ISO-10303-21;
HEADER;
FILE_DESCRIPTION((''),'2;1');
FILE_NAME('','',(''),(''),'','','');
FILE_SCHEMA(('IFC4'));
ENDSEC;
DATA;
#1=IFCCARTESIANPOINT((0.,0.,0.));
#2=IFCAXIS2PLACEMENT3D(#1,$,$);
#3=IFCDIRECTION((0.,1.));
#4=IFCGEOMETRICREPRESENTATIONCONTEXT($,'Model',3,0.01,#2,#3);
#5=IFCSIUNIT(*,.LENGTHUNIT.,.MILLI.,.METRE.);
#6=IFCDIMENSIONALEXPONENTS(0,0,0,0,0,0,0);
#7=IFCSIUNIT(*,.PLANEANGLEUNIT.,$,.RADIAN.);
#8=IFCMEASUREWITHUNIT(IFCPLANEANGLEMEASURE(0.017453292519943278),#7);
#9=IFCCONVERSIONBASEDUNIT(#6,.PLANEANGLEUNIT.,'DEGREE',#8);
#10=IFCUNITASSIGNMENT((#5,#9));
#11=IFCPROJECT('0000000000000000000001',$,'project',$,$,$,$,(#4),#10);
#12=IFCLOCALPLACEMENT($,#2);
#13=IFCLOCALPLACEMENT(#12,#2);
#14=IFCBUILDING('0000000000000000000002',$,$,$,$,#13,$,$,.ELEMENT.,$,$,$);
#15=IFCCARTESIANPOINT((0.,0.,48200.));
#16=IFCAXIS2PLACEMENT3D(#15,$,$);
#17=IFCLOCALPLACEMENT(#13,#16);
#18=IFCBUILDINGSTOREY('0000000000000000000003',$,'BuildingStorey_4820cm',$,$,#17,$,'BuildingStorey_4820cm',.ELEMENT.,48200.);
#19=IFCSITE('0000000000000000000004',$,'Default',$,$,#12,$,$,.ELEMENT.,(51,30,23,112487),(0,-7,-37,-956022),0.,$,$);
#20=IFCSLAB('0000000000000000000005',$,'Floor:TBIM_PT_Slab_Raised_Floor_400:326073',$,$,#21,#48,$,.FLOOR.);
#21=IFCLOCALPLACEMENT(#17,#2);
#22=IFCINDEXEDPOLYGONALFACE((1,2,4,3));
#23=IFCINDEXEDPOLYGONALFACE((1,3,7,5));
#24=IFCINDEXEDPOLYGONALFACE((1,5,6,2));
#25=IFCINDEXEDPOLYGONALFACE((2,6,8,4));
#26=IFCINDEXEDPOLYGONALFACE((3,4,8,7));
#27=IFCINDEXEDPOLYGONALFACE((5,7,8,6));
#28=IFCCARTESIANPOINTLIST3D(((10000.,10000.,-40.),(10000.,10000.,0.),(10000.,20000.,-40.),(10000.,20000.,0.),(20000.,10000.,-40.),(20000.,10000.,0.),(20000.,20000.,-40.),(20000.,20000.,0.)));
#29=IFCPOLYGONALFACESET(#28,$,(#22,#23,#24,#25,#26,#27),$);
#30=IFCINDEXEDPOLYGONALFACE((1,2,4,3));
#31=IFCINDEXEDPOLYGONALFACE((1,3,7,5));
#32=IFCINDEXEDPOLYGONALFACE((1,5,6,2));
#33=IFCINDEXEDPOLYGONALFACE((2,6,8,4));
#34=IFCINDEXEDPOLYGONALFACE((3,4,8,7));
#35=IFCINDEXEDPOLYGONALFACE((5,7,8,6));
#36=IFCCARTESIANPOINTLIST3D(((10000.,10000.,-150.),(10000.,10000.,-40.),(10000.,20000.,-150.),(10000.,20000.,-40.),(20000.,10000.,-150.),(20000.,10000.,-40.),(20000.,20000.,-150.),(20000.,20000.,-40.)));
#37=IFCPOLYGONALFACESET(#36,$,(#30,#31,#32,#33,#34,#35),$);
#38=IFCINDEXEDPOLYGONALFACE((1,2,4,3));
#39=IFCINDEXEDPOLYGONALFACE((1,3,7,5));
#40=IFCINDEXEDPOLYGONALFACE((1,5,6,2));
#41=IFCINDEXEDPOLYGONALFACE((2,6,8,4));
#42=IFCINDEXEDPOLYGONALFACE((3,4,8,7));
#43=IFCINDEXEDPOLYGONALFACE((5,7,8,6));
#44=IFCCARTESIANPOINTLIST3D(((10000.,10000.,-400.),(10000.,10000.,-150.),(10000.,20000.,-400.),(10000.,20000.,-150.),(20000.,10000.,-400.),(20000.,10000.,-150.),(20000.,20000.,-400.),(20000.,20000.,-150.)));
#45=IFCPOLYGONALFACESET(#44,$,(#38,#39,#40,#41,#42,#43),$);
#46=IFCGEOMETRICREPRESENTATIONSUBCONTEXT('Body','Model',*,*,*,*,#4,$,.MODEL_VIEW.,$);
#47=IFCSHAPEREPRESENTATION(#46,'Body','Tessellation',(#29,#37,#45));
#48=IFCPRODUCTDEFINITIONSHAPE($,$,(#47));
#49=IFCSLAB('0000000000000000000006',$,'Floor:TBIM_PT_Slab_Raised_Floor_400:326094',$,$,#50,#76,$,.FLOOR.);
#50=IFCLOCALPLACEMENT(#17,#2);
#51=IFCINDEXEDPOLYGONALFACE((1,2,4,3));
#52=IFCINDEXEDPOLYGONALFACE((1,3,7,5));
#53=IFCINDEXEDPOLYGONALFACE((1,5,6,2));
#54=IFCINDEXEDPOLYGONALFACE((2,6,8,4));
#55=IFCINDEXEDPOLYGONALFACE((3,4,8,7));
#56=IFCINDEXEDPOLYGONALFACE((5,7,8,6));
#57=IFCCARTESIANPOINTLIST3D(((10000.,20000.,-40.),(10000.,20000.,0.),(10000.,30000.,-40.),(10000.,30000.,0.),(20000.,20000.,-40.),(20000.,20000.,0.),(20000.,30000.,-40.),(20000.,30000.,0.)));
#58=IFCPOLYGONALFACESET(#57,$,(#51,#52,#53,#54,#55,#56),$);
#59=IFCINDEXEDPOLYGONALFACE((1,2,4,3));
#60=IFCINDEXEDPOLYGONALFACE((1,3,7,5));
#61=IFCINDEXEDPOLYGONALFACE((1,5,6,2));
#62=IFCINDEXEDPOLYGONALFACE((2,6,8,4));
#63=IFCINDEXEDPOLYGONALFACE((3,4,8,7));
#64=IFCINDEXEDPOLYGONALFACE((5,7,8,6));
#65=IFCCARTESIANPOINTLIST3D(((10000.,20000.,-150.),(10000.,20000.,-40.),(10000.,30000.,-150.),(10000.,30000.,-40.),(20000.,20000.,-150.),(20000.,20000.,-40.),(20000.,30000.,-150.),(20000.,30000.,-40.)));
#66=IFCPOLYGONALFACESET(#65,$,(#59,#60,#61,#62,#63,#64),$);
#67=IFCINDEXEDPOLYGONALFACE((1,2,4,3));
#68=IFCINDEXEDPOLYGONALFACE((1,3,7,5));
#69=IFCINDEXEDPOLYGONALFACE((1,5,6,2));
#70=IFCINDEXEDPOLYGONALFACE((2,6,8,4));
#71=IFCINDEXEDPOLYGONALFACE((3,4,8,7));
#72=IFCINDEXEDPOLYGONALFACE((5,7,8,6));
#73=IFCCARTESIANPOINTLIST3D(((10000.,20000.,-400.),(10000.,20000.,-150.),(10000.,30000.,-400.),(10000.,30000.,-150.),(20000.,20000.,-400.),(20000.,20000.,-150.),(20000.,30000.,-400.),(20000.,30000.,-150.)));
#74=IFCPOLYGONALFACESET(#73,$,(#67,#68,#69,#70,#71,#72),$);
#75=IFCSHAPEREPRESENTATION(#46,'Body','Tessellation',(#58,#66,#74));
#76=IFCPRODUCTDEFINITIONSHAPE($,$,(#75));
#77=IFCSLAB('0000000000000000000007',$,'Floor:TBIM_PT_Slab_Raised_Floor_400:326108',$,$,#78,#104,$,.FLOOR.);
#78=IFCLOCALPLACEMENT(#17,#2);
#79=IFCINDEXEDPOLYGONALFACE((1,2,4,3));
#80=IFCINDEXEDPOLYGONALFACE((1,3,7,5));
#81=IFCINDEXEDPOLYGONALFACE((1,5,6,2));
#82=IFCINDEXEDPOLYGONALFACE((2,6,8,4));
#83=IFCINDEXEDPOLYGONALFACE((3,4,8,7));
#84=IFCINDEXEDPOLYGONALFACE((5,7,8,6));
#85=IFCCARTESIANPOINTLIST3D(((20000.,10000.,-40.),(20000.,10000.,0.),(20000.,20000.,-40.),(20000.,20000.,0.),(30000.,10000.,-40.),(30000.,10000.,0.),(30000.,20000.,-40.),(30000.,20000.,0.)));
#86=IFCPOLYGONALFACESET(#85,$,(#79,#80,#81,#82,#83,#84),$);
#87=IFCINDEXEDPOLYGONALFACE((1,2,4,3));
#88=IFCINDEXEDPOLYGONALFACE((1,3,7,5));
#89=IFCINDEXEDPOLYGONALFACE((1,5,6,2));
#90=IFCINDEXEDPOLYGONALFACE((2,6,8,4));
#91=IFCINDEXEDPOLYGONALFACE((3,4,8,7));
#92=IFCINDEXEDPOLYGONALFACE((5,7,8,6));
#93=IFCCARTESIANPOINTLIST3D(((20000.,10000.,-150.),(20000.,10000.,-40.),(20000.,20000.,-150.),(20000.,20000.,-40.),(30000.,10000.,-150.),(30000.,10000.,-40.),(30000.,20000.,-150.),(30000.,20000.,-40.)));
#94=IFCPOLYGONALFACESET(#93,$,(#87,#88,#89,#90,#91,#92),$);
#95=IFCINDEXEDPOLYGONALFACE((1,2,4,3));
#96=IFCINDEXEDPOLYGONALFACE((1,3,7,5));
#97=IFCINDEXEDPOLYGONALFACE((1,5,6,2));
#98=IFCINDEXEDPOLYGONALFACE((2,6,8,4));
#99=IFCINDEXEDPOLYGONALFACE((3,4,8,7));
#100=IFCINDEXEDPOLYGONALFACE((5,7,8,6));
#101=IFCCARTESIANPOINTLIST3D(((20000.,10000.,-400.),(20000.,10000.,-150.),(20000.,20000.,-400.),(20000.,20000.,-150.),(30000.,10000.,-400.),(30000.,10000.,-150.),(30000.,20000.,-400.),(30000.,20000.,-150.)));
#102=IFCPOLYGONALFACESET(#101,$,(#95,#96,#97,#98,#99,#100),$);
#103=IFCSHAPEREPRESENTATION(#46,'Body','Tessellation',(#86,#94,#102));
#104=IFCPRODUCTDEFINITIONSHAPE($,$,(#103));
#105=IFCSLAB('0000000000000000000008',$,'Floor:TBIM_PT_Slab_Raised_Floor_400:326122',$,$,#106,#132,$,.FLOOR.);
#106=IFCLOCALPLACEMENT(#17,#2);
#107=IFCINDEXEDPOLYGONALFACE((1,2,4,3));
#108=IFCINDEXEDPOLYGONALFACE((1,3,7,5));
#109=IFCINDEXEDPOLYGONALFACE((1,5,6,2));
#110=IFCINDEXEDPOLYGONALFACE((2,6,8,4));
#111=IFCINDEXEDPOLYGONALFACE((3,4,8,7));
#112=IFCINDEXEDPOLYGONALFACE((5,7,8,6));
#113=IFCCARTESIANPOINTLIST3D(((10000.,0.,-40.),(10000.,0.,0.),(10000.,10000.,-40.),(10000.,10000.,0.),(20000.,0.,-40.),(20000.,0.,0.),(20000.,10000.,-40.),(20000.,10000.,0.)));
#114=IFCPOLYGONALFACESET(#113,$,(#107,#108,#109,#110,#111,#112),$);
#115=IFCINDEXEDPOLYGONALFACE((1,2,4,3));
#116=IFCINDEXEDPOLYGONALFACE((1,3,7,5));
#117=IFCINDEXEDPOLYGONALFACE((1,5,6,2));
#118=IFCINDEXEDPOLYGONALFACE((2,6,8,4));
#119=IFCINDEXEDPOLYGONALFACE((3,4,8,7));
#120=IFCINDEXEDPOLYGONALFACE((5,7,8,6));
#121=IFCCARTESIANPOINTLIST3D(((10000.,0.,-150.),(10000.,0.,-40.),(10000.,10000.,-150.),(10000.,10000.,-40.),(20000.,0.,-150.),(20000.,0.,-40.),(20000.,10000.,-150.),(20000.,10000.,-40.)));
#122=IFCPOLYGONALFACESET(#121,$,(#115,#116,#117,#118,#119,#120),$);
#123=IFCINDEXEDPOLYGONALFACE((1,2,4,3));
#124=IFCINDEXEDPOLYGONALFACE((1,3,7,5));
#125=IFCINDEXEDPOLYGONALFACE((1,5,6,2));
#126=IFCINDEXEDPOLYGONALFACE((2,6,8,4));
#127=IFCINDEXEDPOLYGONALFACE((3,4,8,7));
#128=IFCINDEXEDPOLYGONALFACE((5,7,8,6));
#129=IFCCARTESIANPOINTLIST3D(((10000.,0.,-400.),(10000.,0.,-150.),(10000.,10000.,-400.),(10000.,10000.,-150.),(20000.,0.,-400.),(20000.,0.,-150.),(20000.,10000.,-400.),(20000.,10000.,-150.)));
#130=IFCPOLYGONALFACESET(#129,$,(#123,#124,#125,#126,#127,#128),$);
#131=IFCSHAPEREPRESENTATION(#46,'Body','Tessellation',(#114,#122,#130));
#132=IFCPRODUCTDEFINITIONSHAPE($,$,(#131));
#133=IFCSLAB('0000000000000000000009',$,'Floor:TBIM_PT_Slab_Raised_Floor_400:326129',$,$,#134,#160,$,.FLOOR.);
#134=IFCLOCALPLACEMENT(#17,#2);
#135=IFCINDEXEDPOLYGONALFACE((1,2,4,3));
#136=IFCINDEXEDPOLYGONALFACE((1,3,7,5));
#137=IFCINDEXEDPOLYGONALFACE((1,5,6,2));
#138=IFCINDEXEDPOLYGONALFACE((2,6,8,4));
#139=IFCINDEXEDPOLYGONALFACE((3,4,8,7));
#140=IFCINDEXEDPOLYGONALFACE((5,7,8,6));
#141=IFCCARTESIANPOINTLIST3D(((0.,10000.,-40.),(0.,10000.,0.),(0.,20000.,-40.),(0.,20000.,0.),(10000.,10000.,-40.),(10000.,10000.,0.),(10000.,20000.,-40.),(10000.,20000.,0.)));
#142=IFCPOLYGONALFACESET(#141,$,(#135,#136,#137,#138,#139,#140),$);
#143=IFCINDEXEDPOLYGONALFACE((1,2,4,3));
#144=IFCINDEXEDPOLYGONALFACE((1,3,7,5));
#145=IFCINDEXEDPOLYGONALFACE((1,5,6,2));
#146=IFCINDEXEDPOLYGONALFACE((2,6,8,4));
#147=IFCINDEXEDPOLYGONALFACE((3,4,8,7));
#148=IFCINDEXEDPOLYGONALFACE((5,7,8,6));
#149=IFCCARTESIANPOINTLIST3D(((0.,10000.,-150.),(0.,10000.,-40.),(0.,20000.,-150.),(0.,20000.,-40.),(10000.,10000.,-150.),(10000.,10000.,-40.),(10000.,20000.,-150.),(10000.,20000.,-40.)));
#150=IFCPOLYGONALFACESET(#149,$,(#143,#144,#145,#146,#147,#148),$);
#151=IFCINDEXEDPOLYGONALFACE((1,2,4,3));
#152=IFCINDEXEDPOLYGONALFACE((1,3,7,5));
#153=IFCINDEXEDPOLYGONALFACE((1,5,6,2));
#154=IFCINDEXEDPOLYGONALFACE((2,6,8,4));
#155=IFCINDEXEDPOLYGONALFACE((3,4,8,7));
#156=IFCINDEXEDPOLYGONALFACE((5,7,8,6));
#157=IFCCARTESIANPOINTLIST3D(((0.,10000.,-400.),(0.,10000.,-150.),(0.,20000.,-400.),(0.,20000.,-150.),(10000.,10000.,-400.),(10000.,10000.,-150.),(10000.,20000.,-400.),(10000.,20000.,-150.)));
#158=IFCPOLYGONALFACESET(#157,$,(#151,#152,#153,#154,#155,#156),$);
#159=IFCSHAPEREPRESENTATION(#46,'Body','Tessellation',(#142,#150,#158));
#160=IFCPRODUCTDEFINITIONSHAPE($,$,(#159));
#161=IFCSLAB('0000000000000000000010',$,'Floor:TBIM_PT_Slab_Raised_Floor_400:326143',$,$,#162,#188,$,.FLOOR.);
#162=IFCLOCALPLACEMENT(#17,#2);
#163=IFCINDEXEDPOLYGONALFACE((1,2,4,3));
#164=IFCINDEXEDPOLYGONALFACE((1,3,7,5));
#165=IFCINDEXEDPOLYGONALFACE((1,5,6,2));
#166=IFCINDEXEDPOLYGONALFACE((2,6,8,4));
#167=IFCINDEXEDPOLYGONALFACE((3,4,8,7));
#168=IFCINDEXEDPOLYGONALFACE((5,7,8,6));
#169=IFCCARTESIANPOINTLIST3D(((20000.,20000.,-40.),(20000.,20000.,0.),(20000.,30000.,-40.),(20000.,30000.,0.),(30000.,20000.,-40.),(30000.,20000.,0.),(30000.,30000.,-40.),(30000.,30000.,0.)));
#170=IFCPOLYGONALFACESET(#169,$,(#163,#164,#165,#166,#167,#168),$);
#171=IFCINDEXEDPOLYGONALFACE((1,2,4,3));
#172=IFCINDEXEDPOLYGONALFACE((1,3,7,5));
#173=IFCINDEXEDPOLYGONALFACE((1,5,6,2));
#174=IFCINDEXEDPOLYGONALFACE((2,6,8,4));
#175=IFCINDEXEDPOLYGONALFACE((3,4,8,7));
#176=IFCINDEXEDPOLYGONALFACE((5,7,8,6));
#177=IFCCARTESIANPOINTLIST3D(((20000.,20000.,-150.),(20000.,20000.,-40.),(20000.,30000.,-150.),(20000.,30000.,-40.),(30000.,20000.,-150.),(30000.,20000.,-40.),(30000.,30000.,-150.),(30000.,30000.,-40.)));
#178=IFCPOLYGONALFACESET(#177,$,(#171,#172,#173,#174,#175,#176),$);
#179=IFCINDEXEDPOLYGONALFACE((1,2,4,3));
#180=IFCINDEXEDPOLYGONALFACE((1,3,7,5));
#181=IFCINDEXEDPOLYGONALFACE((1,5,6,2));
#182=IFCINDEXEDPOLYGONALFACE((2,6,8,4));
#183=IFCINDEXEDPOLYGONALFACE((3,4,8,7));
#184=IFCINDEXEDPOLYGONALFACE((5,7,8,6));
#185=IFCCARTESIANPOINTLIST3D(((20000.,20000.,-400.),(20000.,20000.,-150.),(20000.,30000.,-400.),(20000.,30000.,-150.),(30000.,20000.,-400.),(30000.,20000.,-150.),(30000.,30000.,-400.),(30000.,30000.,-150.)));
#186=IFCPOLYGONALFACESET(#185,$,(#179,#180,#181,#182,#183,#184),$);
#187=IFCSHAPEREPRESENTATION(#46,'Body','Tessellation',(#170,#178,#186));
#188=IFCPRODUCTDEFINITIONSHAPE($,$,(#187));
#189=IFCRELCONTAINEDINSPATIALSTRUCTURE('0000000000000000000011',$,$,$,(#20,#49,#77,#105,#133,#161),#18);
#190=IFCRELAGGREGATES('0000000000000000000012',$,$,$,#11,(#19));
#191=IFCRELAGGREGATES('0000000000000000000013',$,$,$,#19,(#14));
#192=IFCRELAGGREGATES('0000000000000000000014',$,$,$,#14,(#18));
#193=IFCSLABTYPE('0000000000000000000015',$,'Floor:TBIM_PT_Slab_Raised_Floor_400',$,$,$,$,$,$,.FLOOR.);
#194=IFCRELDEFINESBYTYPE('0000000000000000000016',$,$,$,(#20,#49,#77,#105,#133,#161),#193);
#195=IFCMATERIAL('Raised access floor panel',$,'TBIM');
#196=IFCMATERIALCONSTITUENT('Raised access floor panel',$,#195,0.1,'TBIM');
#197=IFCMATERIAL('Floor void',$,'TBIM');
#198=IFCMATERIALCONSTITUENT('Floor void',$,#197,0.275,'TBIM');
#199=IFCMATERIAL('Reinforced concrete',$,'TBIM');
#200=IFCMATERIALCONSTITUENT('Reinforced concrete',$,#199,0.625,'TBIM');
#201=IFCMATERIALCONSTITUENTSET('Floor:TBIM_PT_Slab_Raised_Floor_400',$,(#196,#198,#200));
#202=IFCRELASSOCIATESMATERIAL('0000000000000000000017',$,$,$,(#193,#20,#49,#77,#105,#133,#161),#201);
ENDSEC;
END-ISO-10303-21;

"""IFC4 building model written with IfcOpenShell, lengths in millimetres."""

from ifc_helpers import new_model, entity, si_unit, converted_unit, direction, frame, origin, place, context, subcontext, project, spatial, indexed_curve, outline, extrude, material, constituent, constituent_set, type_object, element, save


model = new_model("IFC4")

# Units and contexts
model_context = context("Model", 3, precision=0.01, world=origin(), true_north=direction((0.0, 1.0)))
body_context = subcontext(model_context, "Body", "Model", "MODEL_VIEW")
ifc_project = project(units=[si_unit("LENGTHUNIT", "METRE", prefix="MILLI"), converted_unit("PLANEANGLEUNIT", "DEGREE", entity("IfcPlaneAngleMeasure", 0.017453292519943278), si_unit("PLANEANGLEUNIT", "RADIAN"), dimensions=[0, 0, 0, 0, 0, 0, 0])], contexts=[model_context])

# Site, building, storey
site_placement = place(None, origin())
site = spatial("IfcSite", under=ifc_project, at=site_placement, Name="Default", CompositionType="ELEMENT", RefLatitude=(51, 30, 23, 112487), RefLongitude=(0, -7, -37, -956022), RefElevation=0.0)
building_placement = place(site_placement, origin())
building = spatial("IfcBuilding", under=site, at=building_placement, CompositionType="ELEMENT")
storey_placement = place(building_placement, frame((0.0, 0.0, 48200.0)))
storey = spatial("IfcBuildingStorey", under=building, at=storey_placement, Name="BuildingStorey_4820cm", LongName="BuildingStorey_4820cm", CompositionType="ELEMENT", Elevation=48200.0)

# Slabs
ifc_material_1 = material(Name="Raised access floor panel", Category="TBIM")
ifc_constituent_1 = constituent(ifc_material_1, Name="Raised access floor panel", Category="TBIM", fraction=0.1)
ifc_material_2 = material(Name="Floor void", Category="TBIM")
ifc_constituent_2 = constituent(ifc_material_2, Name="Floor void", Category="TBIM", fraction=0.275)
ifc_material_3 = material(Name="Reinforced concrete", Category="TBIM")
ifc_constituent_3 = constituent(ifc_material_3, Name="Reinforced concrete", Category="TBIM", fraction=0.625)
ifc_constituent_set_1 = constituent_set(constituents=[ifc_constituent_1, ifc_constituent_2, ifc_constituent_3], Name="Floor:TBIM_PT_Slab_Raised_Floor_400")
slab_type = type_object("IfcSlabType", Name="Floor:TBIM_PT_Slab_Raised_Floor_400", PredefinedType="FLOOR", material=ifc_constituent_set_1)
slab_1_placement = place(storey_placement, origin())
element("IfcSlab", 1, at=slab_1_placement, inside=storey, type_object=slab_type, material=ifc_constituent_set_1, Name="Floor:TBIM_PT_Slab_Raised_Floor_400:326073", PredefinedType="FLOOR", context=body_context, shape_type="SweptSolid", body=[
    extrude(outline(indexed_curve([(-5000.0, -5000.0), (5000.0, -5000.0), (5000.0, 5000.0), (-5000.0, 5000.0), (-5000.0, -5000.0)], self_intersect=False)), frame((15000.0, 15000.0, -40.0), z_axis=(0.0, 0.0, 1.0), x_axis=(-1.0, 0.0, 0.0)), (0.0, 0.0, 1.0), 40.0),
    extrude(outline(indexed_curve([(-5000.0, -5000.0), (5000.0, -5000.0), (5000.0, 5000.0), (-5000.0, 5000.0), (-5000.0, -5000.0)], self_intersect=False)), frame((15000.0, 15000.0, -150.0), z_axis=(0.0, 0.0, 1.0), x_axis=(-1.0, 0.0, 0.0)), (0.0, 0.0, 1.0), 110.0),
    extrude(outline(indexed_curve([(-5000.0, -5000.0), (5000.0, -5000.0), (5000.0, 5000.0), (-5000.0, 5000.0), (-5000.0, -5000.0)], self_intersect=False)), frame((15000.0, 15000.0, -400.0), z_axis=(0.0, 0.0, 1.0), x_axis=(-1.0, 0.0, 0.0)), (0.0, 0.0, 1.0), 250.0),
])
slab_2_placement = place(storey_placement, origin())
element("IfcSlab", 2, at=slab_2_placement, inside=storey, type_object=slab_type, material=ifc_constituent_set_1, Name="Floor:TBIM_PT_Slab_Raised_Floor_400:326094", PredefinedType="FLOOR", context=body_context, shape_type="SweptSolid", body=[
    extrude(outline(indexed_curve([(-5000.0, -5000.0), (5000.0, -5000.0), (5000.0, 5000.0), (-5000.0, 5000.0), (-5000.0, -5000.0)], self_intersect=False)), frame((15000.0, 25000.0, -40.0), z_axis=(0.0, 0.0, 1.0), x_axis=(-1.0, 0.0, 0.0)), (0.0, 0.0, 1.0), 40.0),
    extrude(outline(indexed_curve([(-5000.0, -5000.0), (5000.0, -5000.0), (5000.0, 5000.0), (-5000.0, 5000.0), (-5000.0, -5000.0)], self_intersect=False)), frame((15000.0, 25000.0, -150.0), z_axis=(0.0, 0.0, 1.0), x_axis=(-1.0, 0.0, 0.0)), (0.0, 0.0, 1.0), 110.0),
    extrude(outline(indexed_curve([(-5000.0, -5000.0), (5000.0, -5000.0), (5000.0, 5000.0), (-5000.0, 5000.0), (-5000.0, -5000.0)], self_intersect=False)), frame((15000.0, 25000.0, -400.0), z_axis=(0.0, 0.0, 1.0), x_axis=(-1.0, 0.0, 0.0)), (0.0, 0.0, 1.0), 250.0),
])
slab_3_placement = place(storey_placement, origin())
element("IfcSlab", 3, at=slab_3_placement, inside=storey, type_object=slab_type, material=ifc_constituent_set_1, Name="Floor:TBIM_PT_Slab_Raised_Floor_400:326108", PredefinedType="FLOOR", context=body_context, shape_type="SweptSolid", body=[
    extrude(outline(indexed_curve([(-5000.0, -5000.0), (5000.0, -5000.0), (5000.0, 5000.0), (-5000.0, 5000.0), (-5000.0, -5000.0)], self_intersect=False)), frame((25000.0, 15000.0, -40.0), z_axis=(0.0, 0.0, 1.0), x_axis=(-1.0, 0.0, 0.0)), (0.0, 0.0, 1.0), 40.0),
    extrude(outline(indexed_curve([(-5000.0, -5000.0), (5000.0, -5000.0), (5000.0, 5000.0), (-5000.0, 5000.0), (-5000.0, -5000.0)], self_intersect=False)), frame((25000.0, 15000.0, -150.0), z_axis=(0.0, 0.0, 1.0), x_axis=(-1.0, 0.0, 0.0)), (0.0, 0.0, 1.0), 110.0),
    extrude(outline(indexed_curve([(-5000.0, -5000.0), (5000.0, -5000.0), (5000.0, 5000.0), (-5000.0, 5000.0), (-5000.0, -5000.0)], self_intersect=False)), frame((25000.0, 15000.0, -400.0), z_axis=(0.0, 0.0, 1.0), x_axis=(-1.0, 0.0, 0.0)), (0.0, 0.0, 1.0), 250.0),
])
slab_4_placement = place(storey_placement, origin())
element("IfcSlab", 4, at=slab_4_placement, inside=storey, type_object=slab_type, material=ifc_constituent_set_1, Name="Floor:TBIM_PT_Slab_Raised_Floor_400:326122", PredefinedType="FLOOR", context=body_context, shape_type="SweptSolid", body=[
    extrude(outline(indexed_curve([(-5000.0, -5000.0), (5000.0, -5000.0), (5000.0, 5000.0), (-5000.0, 5000.0), (-5000.0, -5000.0)], self_intersect=False)), frame((15000.0, 5000.0, -40.0), z_axis=(0.0, 0.0, 1.0), x_axis=(0.0, 1.0, 0.0)), (0.0, 0.0, 1.0), 40.0),
    extrude(outline(indexed_curve([(-5000.0, -5000.0), (5000.0, -5000.0), (5000.0, 5000.0), (-5000.0, 5000.0), (-5000.0, -5000.0)], self_intersect=False)), frame((15000.0, 5000.0, -150.0), z_axis=(0.0, 0.0, 1.0), x_axis=(0.0, 1.0, 0.0)), (0.0, 0.0, 1.0), 110.0),
    extrude(outline(indexed_curve([(-5000.0, -5000.0), (5000.0, -5000.0), (5000.0, 5000.0), (-5000.0, 5000.0), (-5000.0, -5000.0)], self_intersect=False)), frame((15000.0, 5000.0, -400.0), z_axis=(0.0, 0.0, 1.0), x_axis=(0.0, 1.0, 0.0)), (0.0, 0.0, 1.0), 250.0),
])
slab_5_placement = place(storey_placement, origin())
element("IfcSlab", 5, at=slab_5_placement, inside=storey, type_object=slab_type, material=ifc_constituent_set_1, Name="Floor:TBIM_PT_Slab_Raised_Floor_400:326129", PredefinedType="FLOOR", context=body_context, shape_type="SweptSolid", body=[
    extrude(outline(indexed_curve([(-5000.0, -5000.0), (5000.0, -5000.0), (5000.0, 5000.0), (-5000.0, 5000.0), (-5000.0, -5000.0)], self_intersect=False)), frame((5000.0, 15000.0, -40.0), z_axis=(0.0, 0.0, 1.0), x_axis=(0.0, 1.0, 0.0)), (0.0, 0.0, 1.0), 40.0),
    extrude(outline(indexed_curve([(-5000.0, -5000.0), (5000.0, -5000.0), (5000.0, 5000.0), (-5000.0, 5000.0), (-5000.0, -5000.0)], self_intersect=False)), frame((5000.0, 15000.0, -150.0), z_axis=(0.0, 0.0, 1.0), x_axis=(0.0, 1.0, 0.0)), (0.0, 0.0, 1.0), 110.0),
    extrude(outline(indexed_curve([(-5000.0, -5000.0), (5000.0, -5000.0), (5000.0, 5000.0), (-5000.0, 5000.0), (-5000.0, -5000.0)], self_intersect=False)), frame((5000.0, 15000.0, -400.0), z_axis=(0.0, 0.0, 1.0), x_axis=(0.0, 1.0, 0.0)), (0.0, 0.0, 1.0), 250.0),
])
slab_6_placement = place(storey_placement, origin())
element("IfcSlab", 6, at=slab_6_placement, inside=storey, type_object=slab_type, material=ifc_constituent_set_1, Name="Floor:TBIM_PT_Slab_Raised_Floor_400:326143", PredefinedType="FLOOR", context=body_context, shape_type="SweptSolid", body=[
    extrude(outline(indexed_curve([(-5000.0, -5000.0), (5000.0, -5000.0), (5000.0, 5000.0), (-5000.0, 5000.0), (-5000.0, -5000.0)], self_intersect=False)), frame((25000.0, 25000.0, -40.0), z_axis=(0.0, 0.0, 1.0), x_axis=(-1.0, 0.0, 0.0)), (0.0, 0.0, 1.0), 40.0),
    extrude(outline(indexed_curve([(-5000.0, -5000.0), (5000.0, -5000.0), (5000.0, 5000.0), (-5000.0, 5000.0), (-5000.0, -5000.0)], self_intersect=False)), frame((25000.0, 25000.0, -150.0), z_axis=(0.0, 0.0, 1.0), x_axis=(-1.0, 0.0, 0.0)), (0.0, 0.0, 1.0), 110.0),
    extrude(outline(indexed_curve([(-5000.0, -5000.0), (5000.0, -5000.0), (5000.0, 5000.0), (-5000.0, 5000.0), (-5000.0, -5000.0)], self_intersect=False)), frame((25000.0, 25000.0, -400.0), z_axis=(0.0, 0.0, 1.0), x_axis=(-1.0, 0.0, 0.0)), (0.0, 0.0, 1.0), 250.0),
])

save(model, "model.ifc")
